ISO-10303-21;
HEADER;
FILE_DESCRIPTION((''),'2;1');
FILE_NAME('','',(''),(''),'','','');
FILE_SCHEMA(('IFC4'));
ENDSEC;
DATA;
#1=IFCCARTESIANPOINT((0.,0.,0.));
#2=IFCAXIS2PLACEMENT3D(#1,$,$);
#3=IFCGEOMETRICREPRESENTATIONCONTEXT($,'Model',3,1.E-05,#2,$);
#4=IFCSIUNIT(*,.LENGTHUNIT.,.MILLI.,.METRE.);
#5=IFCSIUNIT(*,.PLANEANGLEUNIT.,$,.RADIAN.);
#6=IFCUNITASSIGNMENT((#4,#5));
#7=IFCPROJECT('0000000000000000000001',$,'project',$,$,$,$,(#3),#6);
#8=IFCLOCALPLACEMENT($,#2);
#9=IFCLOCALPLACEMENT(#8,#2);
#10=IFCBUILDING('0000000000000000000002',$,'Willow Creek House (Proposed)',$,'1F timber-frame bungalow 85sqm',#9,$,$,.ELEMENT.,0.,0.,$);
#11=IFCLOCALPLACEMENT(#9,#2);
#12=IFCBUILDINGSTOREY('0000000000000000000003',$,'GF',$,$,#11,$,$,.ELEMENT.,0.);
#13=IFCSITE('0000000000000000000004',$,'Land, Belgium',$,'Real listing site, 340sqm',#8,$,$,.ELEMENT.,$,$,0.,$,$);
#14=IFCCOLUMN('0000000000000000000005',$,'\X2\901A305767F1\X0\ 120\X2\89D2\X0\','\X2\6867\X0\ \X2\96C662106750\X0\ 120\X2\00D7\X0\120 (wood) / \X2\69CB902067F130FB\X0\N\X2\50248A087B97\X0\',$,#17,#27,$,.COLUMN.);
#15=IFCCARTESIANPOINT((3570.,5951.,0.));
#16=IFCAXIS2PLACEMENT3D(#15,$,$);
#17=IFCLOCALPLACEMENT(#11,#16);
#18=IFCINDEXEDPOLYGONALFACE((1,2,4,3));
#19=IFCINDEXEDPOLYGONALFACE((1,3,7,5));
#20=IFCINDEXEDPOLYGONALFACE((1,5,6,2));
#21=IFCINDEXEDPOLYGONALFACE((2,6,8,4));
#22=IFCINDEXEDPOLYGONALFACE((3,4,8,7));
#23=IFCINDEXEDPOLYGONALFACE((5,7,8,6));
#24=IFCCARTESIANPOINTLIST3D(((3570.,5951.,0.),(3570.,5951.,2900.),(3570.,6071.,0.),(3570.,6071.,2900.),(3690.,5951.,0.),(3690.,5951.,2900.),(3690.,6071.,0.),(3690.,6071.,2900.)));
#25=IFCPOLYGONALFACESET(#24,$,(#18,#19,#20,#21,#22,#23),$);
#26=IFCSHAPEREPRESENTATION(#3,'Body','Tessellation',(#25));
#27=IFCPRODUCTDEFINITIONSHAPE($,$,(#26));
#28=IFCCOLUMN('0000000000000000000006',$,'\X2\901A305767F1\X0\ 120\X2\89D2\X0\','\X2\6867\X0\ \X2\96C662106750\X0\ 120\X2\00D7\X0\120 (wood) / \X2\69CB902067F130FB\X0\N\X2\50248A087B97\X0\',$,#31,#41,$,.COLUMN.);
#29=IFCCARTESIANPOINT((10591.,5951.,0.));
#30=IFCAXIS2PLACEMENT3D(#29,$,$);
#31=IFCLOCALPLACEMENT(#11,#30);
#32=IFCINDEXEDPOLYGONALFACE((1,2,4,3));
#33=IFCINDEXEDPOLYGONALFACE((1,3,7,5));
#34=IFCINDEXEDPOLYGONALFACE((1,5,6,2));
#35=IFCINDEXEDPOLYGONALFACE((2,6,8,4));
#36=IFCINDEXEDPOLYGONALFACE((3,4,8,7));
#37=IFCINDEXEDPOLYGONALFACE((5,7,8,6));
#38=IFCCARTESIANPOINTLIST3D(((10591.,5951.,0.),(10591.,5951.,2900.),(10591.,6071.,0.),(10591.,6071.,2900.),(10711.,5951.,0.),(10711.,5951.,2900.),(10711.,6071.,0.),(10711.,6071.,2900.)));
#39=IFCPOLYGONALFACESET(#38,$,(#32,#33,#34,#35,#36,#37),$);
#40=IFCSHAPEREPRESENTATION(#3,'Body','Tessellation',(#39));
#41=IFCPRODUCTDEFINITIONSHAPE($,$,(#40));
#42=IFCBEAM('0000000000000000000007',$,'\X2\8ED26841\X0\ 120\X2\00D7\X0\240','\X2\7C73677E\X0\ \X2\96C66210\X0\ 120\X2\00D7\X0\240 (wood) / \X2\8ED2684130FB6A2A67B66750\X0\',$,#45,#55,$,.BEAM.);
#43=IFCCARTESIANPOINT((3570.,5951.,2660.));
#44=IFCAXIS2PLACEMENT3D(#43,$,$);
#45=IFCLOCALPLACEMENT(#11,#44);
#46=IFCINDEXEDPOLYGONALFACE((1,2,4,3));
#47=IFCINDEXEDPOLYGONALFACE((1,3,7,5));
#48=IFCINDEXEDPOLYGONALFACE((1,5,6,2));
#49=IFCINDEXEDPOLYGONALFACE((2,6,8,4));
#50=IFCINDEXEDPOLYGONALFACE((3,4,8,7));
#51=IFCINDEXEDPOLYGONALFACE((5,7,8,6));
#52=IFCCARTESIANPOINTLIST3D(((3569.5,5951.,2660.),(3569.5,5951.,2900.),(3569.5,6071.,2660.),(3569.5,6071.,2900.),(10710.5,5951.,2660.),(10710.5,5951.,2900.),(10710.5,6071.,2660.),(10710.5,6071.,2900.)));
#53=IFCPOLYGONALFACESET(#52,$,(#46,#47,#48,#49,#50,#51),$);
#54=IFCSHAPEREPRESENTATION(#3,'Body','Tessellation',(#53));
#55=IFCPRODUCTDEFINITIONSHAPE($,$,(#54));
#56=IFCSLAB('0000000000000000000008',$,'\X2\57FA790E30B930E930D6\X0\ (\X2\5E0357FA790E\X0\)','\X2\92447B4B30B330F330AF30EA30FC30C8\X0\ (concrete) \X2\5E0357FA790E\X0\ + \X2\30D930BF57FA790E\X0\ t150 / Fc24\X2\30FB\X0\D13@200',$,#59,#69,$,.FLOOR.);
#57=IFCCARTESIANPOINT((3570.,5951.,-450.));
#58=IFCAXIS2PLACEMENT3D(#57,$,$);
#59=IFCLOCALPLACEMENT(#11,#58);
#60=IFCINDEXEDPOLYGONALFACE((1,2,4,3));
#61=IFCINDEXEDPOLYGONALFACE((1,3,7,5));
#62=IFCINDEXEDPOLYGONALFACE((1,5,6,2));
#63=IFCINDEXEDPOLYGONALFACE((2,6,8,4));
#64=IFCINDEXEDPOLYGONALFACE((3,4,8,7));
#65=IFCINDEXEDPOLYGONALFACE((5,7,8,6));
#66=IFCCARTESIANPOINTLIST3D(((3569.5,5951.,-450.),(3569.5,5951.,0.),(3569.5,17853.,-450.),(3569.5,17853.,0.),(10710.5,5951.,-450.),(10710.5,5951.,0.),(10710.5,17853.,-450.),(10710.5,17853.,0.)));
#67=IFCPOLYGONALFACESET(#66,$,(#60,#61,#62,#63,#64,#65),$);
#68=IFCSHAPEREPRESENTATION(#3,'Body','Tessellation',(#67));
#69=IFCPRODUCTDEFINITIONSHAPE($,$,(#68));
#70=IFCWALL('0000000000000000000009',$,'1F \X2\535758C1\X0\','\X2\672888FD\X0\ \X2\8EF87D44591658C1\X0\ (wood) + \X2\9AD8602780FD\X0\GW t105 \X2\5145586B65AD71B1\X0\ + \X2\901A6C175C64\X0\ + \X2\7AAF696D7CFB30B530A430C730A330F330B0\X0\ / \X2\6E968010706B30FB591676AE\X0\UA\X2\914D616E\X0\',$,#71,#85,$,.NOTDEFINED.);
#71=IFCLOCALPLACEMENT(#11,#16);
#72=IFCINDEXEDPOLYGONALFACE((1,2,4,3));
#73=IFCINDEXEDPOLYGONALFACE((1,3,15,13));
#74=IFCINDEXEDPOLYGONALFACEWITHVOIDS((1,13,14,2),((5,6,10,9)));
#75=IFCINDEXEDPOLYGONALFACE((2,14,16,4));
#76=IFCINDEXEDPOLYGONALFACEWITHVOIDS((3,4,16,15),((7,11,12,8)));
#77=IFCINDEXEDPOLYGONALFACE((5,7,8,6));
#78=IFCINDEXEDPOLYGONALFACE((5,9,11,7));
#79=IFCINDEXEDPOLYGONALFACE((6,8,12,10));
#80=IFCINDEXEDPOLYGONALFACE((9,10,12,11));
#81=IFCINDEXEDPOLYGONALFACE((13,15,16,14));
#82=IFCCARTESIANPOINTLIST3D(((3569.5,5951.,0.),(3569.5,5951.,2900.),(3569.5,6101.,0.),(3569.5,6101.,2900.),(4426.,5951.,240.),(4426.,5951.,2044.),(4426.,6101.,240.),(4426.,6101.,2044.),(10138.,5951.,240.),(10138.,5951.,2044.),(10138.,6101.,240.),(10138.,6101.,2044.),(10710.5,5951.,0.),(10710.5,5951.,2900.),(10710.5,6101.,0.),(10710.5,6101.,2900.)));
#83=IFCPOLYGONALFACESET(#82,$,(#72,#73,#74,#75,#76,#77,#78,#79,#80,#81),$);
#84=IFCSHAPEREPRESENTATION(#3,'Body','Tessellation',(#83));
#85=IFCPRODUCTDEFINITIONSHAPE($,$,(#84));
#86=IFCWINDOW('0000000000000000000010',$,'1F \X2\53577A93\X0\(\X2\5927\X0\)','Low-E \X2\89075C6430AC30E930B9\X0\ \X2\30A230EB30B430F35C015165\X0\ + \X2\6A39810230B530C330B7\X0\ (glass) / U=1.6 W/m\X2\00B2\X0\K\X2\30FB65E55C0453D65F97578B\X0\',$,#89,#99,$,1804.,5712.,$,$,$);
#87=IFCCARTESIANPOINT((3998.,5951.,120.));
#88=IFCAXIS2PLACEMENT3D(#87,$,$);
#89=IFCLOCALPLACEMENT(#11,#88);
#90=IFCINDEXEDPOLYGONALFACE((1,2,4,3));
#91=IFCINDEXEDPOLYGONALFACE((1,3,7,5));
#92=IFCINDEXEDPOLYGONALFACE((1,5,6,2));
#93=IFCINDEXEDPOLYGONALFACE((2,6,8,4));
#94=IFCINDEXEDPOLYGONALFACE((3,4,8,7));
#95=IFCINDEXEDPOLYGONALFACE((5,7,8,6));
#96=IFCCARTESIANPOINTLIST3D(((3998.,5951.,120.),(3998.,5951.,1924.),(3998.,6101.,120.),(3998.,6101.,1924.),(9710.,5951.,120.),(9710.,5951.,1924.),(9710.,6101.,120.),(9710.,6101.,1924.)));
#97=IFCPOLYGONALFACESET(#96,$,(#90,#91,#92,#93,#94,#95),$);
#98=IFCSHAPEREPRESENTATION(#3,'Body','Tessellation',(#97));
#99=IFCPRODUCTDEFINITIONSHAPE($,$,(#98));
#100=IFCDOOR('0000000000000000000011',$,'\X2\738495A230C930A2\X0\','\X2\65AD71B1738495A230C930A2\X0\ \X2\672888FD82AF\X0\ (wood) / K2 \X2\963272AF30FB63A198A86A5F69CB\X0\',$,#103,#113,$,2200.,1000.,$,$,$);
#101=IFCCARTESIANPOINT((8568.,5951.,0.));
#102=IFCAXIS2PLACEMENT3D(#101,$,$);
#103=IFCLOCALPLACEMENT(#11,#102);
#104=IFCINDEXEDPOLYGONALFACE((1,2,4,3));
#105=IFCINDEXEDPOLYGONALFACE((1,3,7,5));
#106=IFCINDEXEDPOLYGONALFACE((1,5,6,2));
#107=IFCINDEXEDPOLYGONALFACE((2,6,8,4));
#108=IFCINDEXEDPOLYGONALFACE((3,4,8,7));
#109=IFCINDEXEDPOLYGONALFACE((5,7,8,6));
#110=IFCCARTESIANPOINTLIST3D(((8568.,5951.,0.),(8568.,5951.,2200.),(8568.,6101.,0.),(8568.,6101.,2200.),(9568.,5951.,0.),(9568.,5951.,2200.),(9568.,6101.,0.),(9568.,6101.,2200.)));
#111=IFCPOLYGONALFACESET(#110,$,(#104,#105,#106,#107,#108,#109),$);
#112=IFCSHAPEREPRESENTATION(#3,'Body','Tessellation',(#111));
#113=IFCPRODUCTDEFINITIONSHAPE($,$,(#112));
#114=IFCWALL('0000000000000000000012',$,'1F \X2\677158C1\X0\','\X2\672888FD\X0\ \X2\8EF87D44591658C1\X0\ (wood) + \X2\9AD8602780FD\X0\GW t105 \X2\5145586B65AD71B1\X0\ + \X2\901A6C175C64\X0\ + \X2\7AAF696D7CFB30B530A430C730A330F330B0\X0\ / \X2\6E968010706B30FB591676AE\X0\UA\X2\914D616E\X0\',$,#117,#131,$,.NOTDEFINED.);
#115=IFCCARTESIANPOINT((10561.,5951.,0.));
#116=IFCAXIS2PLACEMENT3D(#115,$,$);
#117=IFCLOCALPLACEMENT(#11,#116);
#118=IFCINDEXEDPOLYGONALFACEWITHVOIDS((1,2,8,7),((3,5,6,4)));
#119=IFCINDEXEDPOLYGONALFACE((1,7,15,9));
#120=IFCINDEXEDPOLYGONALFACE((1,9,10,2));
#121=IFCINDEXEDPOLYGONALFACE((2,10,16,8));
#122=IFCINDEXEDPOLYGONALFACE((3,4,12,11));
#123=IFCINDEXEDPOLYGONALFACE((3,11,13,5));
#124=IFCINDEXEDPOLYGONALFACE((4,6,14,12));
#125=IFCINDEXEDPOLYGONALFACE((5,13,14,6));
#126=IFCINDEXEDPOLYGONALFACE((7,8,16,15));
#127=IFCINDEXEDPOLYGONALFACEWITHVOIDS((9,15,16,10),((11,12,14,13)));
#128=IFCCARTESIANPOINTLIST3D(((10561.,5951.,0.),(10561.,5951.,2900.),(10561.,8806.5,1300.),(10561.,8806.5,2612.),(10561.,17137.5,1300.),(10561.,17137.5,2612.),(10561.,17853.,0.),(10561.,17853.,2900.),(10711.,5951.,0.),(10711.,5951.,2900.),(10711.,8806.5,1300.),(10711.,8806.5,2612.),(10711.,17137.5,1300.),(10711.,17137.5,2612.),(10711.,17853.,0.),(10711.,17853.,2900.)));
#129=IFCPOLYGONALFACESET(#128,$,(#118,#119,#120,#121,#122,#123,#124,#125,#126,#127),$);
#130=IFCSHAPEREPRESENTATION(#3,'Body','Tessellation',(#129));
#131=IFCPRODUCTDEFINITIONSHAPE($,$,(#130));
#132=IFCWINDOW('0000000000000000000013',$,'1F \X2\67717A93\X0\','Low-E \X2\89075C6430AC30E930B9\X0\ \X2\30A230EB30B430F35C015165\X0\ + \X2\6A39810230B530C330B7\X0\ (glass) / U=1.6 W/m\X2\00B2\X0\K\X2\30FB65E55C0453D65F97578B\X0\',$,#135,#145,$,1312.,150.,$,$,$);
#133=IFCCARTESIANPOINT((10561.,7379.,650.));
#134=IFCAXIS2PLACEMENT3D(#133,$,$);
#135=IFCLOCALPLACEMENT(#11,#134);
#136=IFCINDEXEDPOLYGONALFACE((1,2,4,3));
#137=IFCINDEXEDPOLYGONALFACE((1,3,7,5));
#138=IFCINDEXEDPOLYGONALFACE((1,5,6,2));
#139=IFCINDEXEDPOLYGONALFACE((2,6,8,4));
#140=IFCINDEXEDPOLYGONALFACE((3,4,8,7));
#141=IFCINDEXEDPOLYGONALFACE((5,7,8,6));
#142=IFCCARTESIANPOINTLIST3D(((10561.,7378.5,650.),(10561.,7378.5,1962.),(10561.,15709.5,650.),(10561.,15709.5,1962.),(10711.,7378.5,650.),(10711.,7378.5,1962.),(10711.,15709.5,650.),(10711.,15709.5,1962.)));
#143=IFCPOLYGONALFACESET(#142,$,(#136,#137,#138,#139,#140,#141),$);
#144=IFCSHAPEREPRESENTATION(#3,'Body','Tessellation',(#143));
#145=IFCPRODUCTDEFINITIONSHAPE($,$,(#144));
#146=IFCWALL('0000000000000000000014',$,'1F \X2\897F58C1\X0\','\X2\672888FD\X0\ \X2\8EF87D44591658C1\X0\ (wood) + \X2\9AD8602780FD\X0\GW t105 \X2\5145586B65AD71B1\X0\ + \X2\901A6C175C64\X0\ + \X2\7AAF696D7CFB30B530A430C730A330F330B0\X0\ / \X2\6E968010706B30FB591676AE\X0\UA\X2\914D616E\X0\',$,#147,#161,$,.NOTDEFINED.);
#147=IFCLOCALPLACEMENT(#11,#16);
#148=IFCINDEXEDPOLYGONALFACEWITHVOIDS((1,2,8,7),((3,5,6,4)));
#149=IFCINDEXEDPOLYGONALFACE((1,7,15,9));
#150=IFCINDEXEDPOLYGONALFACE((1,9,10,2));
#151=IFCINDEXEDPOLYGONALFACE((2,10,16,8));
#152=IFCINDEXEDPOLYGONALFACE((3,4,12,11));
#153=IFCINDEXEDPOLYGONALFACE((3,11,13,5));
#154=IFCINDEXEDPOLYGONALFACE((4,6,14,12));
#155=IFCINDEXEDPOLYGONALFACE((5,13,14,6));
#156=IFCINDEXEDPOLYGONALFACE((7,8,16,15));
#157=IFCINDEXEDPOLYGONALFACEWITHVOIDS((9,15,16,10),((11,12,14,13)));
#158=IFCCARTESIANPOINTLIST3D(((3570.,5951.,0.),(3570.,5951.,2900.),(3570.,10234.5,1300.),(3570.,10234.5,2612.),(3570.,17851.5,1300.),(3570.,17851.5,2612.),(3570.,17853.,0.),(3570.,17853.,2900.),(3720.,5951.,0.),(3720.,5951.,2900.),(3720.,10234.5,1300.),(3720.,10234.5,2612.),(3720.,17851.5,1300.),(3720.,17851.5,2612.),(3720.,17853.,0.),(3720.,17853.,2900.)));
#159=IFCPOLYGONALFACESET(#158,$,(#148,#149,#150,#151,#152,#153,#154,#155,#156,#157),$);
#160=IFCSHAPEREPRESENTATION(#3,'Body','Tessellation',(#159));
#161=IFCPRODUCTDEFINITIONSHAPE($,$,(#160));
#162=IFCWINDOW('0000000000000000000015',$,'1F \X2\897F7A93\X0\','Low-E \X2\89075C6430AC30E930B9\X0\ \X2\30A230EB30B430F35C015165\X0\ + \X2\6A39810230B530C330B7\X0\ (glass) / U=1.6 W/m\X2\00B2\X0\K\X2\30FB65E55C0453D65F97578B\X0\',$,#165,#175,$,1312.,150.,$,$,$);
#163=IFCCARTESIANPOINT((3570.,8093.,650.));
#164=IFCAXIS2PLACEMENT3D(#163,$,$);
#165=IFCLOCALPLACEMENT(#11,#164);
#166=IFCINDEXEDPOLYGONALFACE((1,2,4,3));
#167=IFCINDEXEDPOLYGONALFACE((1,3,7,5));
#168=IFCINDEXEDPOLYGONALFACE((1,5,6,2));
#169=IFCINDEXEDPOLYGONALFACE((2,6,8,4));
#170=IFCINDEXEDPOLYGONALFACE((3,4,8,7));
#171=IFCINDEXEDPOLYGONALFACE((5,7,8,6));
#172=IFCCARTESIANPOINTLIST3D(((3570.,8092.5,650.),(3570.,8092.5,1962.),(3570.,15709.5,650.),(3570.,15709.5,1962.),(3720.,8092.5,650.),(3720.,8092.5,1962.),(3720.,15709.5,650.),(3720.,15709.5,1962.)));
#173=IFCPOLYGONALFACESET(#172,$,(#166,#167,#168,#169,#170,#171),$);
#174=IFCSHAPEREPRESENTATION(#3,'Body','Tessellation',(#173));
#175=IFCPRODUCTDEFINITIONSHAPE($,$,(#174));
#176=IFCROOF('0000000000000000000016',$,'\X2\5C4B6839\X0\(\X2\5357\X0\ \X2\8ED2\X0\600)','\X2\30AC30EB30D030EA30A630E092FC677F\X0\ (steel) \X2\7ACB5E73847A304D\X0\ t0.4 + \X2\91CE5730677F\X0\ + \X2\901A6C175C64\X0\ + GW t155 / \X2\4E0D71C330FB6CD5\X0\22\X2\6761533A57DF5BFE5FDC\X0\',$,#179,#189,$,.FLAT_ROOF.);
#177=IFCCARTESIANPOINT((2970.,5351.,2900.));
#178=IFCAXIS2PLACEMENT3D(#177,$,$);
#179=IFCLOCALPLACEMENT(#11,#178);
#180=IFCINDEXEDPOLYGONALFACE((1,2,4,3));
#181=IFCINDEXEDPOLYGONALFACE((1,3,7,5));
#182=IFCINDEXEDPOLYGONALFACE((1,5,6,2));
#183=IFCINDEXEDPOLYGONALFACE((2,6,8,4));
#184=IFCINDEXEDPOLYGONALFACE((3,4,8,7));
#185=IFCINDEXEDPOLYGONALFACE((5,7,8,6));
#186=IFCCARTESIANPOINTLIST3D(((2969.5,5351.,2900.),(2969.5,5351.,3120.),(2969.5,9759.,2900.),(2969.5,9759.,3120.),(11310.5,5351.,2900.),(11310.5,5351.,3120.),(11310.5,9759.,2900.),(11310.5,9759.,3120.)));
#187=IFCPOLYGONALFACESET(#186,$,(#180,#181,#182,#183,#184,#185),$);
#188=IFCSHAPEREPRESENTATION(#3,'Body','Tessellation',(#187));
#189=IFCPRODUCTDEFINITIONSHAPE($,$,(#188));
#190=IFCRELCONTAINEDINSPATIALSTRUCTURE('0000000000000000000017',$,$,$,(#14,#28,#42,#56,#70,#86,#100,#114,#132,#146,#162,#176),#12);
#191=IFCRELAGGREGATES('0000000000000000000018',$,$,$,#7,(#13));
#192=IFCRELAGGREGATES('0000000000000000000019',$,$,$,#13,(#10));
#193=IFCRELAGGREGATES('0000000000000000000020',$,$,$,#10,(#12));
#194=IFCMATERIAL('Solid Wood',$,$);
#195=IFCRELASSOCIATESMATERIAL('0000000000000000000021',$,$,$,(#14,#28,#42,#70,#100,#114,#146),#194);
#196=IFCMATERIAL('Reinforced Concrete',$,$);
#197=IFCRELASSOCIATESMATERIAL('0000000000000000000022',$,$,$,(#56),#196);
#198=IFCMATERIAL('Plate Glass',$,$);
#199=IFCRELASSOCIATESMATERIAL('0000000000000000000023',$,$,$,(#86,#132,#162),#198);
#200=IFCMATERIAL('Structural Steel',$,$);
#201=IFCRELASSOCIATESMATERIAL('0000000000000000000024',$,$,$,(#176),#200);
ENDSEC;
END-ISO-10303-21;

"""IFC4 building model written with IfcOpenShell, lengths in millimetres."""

from ifc_helpers import new_model, si_unit, frame, frame_2d, origin, place, context, project, spatial, rectangle, extrude, material, element, fill, save


model = new_model("IFC4")

# Units and contexts
model_context = context("Model", 3, precision=1e-05, world=origin())
ifc_project = project(units=[si_unit("LENGTHUNIT", "METRE", prefix="MILLI"), si_unit("PLANEANGLEUNIT", "RADIAN")], contexts=[model_context])

# Site, building, storey
site_placement = place(None, origin())
site = spatial("IfcSite", under=ifc_project, at=site_placement, Name="Land, Belgium", ObjectType="Real listing site, 340sqm", CompositionType="ELEMENT", RefElevation=0.0)
building_placement = place(site_placement, origin())
building = spatial("IfcBuilding", under=site, at=building_placement, Name="Willow Creek House (Proposed)", ObjectType="1F timber-frame bungalow 85sqm", CompositionType="ELEMENT", ElevationOfRefHeight=0.0, ElevationOfTerrain=0.0)
storey_placement = place(building_placement, origin())
storey = spatial("IfcBuildingStorey", under=building, at=storey_placement, Name="GF", CompositionType="ELEMENT", Elevation=0.0)

# Columns
ifc_material_1 = material(Name="Solid Wood")
column_1_placement = place(storey_placement, frame((3570.0, 5951.0, 0.0)))
element("IfcColumn", 1, at=column_1_placement, inside=storey, material=ifc_material_1, Name="通し柱 120角", Description="桧 集成材 120×120 (wood) / 構造柱・N値計算", PredefinedType="COLUMN", context=model_context, shape_type="SweptSolid", body=[
    extrude(rectangle(XDim=120.0, YDim=120.0, at=frame_2d((60.0, 60.0))), frame((3570.0, 5951.0, 0.0)), (0.0, 0.0, 1.0), 2900.0),
])
column_2_placement = place(storey_placement, frame((10591.0, 5951.0, 0.0)))
element("IfcColumn", 2, at=column_2_placement, inside=storey, material=ifc_material_1, Name="通し柱 120角", Description="桧 集成材 120×120 (wood) / 構造柱・N値計算", PredefinedType="COLUMN", context=model_context, shape_type="SweptSolid", body=[
    extrude(rectangle(XDim=120.0, YDim=120.0, at=frame_2d((60.0, 60.0))), frame((10591.0, 5951.0, 0.0)), (0.0, 0.0, 1.0), 2900.0),
])

# Beam
beam_1_placement = place(storey_placement, frame((3570.0, 5951.0, 2660.0)))
element("IfcBeam", 3, at=beam_1_placement, inside=storey, material=ifc_material_1, Name="軒桁 120×240", Description="米松 集成 120×240 (wood) / 軒桁・横架材", PredefinedType="BEAM", context=model_context, shape_type="SweptSolid", body=[
    extrude(rectangle(XDim=7141.0, YDim=120.0, at=frame_2d((3570.0, 60.0))), frame((3570.0, 5951.0, 2660.0)), (0.0, 0.0, 1.0), 240.0),
])

# Slab
ifc_material_2 = material(Name="Reinforced Concrete")
slab_1_placement = place(storey_placement, frame((3570.0, 5951.0, -450.0)))
element("IfcSlab", 4, at=slab_1_placement, inside=storey, material=ifc_material_2, Name="基礎スラブ (布基礎)", Description="鉄筋コンクリート (concrete) 布基礎 + ベタ基礎 t150 / Fc24・D13@200", PredefinedType="FLOOR", context=model_context, shape_type="SweptSolid", body=[
    extrude(rectangle(XDim=7141.0, YDim=11902.0, at=frame_2d((3570.0, 5951.0))), frame((3570.0, 5951.0, -450.0)), (0.0, 0.0, 1.0), 450.0),
])

# Wall, openings, window, door
wall_1_placement = place(storey_placement, frame((3570.0, 5951.0, 0.0)))
wall_1 = element("IfcWall", 5, at=wall_1_placement, inside=storey, material=ifc_material_1, Name="1F 南壁", Description="木製 軸組外壁 (wood) + 高性能GW t105 充填断熱 + 通気層 + 窯業系サイディング / 準耐火・外皮UA配慮", PredefinedType="NOTDEFINED", context=model_context, shape_type="SweptSolid", body=[
    extrude(rectangle(XDim=7141.0, YDim=150.0, at=frame_2d((3570.0, 75.0))), frame((3570.0, 5951.0, 0.0)), (0.0, 0.0, 1.0), 2900.0),
])
opening_1_placement = place(storey_placement, frame((3998.0, 5951.0, 120.0)))
opening_1 = element("IfcOpeningElement", 6, at=opening_1_placement, cuts=wall_1, PredefinedType="NOTDEFINED", context=model_context, shape_type="SweptSolid", body=[
    extrude(rectangle(XDim=5712.0, YDim=150.0, at=frame_2d((2856.0, 75.0))), frame((3998.0, 5951.0, 120.0)), (0.0, 0.0, 1.0), 1804.0),
])
opening_2_placement = place(storey_placement, frame((8568.0, 5951.0, 0.0)))
opening_2 = element("IfcOpeningElement", 7, at=opening_2_placement, cuts=wall_1, PredefinedType="NOTDEFINED", context=model_context, shape_type="SweptSolid", body=[
    extrude(rectangle(XDim=1000.0, YDim=150.0, at=frame_2d((500.0, 75.0))), frame((8568.0, 5951.0, 0.0)), (0.0, 0.0, 1.0), 2200.0),
])
ifc_material_3 = material(Name="Plate Glass")
window_1_placement = place(storey_placement, frame((3998.0, 5951.0, 120.0)))
window_1 = element("IfcWindow", 8, at=window_1_placement, inside=storey, material=ifc_material_3, Name="1F 南窓(大)", Description="Low-E 複層ガラス アルゴン封入 + 樹脂サッシ (glass) / U=1.6 W/m²K・日射取得型", OverallHeight=1804.0, OverallWidth=5712.0, context=model_context, shape_type="SweptSolid", body=[
    extrude(rectangle(XDim=5712.0, YDim=150.0, at=frame_2d((2856.0, 75.0))), frame((3998.0, 5951.0, 120.0)), (0.0, 0.0, 1.0), 1804.0),
])
fill(opening_1, window_1)
door_placement = place(storey_placement, frame((8568.0, 5951.0, 0.0)))
door = element("IfcDoor", 9, at=door_placement, inside=storey, material=ifc_material_1, Name="玄関ドア", Description="断熱玄関ドア 木製芯 (wood) / K2 防犯・採風機構", OverallHeight=2200.0, OverallWidth=1000.0, context=model_context, shape_type="SweptSolid", body=[
    extrude(rectangle(XDim=1000.0, YDim=150.0, at=frame_2d((500.0, 75.0))), frame((8568.0, 5951.0, 0.0)), (0.0, 0.0, 1.0), 2200.0),
])
fill(opening_2, door)

# Walls, openings, windows
wall_2_placement = place(storey_placement, frame((10561.0, 5951.0, 0.0)))
wall_2 = element("IfcWall", 10, at=wall_2_placement, inside=storey, material=ifc_material_1, Name="1F 東壁", Description="木製 軸組外壁 (wood) + 高性能GW t105 充填断熱 + 通気層 + 窯業系サイディング / 準耐火・外皮UA配慮", PredefinedType="NOTDEFINED", context=model_context, shape_type="SweptSolid", body=[
    extrude(rectangle(XDim=150.0, YDim=11902.0, at=frame_2d((75.0, 5951.0))), frame((10561.0, 5951.0, 0.0)), (0.0, 0.0, 1.0), 2900.0),
])
opening_3_placement = place(storey_placement, frame((10561.0, 7379.0, 650.0)))
opening_3 = element("IfcOpeningElement", 11, at=opening_3_placement, cuts=wall_2, PredefinedType="NOTDEFINED", context=model_context, shape_type="SweptSolid", body=[
    extrude(rectangle(XDim=150.0, YDim=8331.0, at=frame_2d((75.0, 4165.0))), frame((10561.0, 7379.0, 650.0)), (0.0, 0.0, 1.0), 1312.0),
])
window_2_placement = place(storey_placement, frame((10561.0, 7379.0, 650.0)))
window_2 = element("IfcWindow", 12, at=window_2_placement, inside=storey, material=ifc_material_3, Name="1F 東窓", Description="Low-E 複層ガラス アルゴン封入 + 樹脂サッシ (glass) / U=1.6 W/m²K・日射取得型", OverallHeight=1312.0, OverallWidth=150.0, context=model_context, shape_type="SweptSolid", body=[
    extrude(rectangle(XDim=150.0, YDim=8331.0, at=frame_2d((75.0, 4165.0))), frame((10561.0, 7379.0, 650.0)), (0.0, 0.0, 1.0), 1312.0),
])
fill(opening_3, window_2)
wall_3_placement = place(storey_placement, frame((3570.0, 5951.0, 0.0)))
wall_3 = element("IfcWall", 13, at=wall_3_placement, inside=storey, material=ifc_material_1, Name="1F 西壁", Description="木製 軸組外壁 (wood) + 高性能GW t105 充填断熱 + 通気層 + 窯業系サイディング / 準耐火・外皮UA配慮", PredefinedType="NOTDEFINED", context=model_context, shape_type="SweptSolid", body=[
    extrude(rectangle(XDim=150.0, YDim=11902.0, at=frame_2d((75.0, 5951.0))), frame((3570.0, 5951.0, 0.0)), (0.0, 0.0, 1.0), 2900.0),
])
opening_4_placement = place(storey_placement, frame((3570.0, 8093.0, 650.0)))
opening_4 = element("IfcOpeningElement", 14, at=opening_4_placement, cuts=wall_3, PredefinedType="NOTDEFINED", context=model_context, shape_type="SweptSolid", body=[
    extrude(rectangle(XDim=150.0, YDim=7617.0, at=frame_2d((75.0, 3808.0))), frame((3570.0, 8093.0, 650.0)), (0.0, 0.0, 1.0), 1312.0),
])
window_3_placement = place(storey_placement, frame((3570.0, 8093.0, 650.0)))
window_3 = element("IfcWindow", 15, at=window_3_placement, inside=storey, material=ifc_material_3, Name="1F 西窓", Description="Low-E 複層ガラス アルゴン封入 + 樹脂サッシ (glass) / U=1.6 W/m²K・日射取得型", OverallHeight=1312.0, OverallWidth=150.0, context=model_context, shape_type="SweptSolid", body=[
    extrude(rectangle(XDim=150.0, YDim=7617.0, at=frame_2d((75.0, 3808.0))), frame((3570.0, 8093.0, 650.0)), (0.0, 0.0, 1.0), 1312.0),
])
fill(opening_4, window_3)

# Roof
ifc_material_4 = material(Name="Structural Steel")
roof_placement = place(storey_placement, frame((2970.0, 5351.0, 2900.0)))
element("IfcRoof", 16, at=roof_placement, inside=storey, material=ifc_material_4, Name="屋根(南 軒600)", Description="ガルバリウム鋼板 (steel) 立平葺き t0.4 + 野地板 + 通気層 + GW t155 / 不燃・法22条区域対応", PredefinedType="FLAT_ROOF", context=model_context, shape_type="SweptSolid", body=[
    extrude(rectangle(XDim=8341.0, YDim=4408.0, at=frame_2d((4170.0, 2204.0))), frame((2970.0, 5351.0, 2900.0)), (0.0, 0.0, 1.0), 220.0),
])

save(model, "model.ifc")
